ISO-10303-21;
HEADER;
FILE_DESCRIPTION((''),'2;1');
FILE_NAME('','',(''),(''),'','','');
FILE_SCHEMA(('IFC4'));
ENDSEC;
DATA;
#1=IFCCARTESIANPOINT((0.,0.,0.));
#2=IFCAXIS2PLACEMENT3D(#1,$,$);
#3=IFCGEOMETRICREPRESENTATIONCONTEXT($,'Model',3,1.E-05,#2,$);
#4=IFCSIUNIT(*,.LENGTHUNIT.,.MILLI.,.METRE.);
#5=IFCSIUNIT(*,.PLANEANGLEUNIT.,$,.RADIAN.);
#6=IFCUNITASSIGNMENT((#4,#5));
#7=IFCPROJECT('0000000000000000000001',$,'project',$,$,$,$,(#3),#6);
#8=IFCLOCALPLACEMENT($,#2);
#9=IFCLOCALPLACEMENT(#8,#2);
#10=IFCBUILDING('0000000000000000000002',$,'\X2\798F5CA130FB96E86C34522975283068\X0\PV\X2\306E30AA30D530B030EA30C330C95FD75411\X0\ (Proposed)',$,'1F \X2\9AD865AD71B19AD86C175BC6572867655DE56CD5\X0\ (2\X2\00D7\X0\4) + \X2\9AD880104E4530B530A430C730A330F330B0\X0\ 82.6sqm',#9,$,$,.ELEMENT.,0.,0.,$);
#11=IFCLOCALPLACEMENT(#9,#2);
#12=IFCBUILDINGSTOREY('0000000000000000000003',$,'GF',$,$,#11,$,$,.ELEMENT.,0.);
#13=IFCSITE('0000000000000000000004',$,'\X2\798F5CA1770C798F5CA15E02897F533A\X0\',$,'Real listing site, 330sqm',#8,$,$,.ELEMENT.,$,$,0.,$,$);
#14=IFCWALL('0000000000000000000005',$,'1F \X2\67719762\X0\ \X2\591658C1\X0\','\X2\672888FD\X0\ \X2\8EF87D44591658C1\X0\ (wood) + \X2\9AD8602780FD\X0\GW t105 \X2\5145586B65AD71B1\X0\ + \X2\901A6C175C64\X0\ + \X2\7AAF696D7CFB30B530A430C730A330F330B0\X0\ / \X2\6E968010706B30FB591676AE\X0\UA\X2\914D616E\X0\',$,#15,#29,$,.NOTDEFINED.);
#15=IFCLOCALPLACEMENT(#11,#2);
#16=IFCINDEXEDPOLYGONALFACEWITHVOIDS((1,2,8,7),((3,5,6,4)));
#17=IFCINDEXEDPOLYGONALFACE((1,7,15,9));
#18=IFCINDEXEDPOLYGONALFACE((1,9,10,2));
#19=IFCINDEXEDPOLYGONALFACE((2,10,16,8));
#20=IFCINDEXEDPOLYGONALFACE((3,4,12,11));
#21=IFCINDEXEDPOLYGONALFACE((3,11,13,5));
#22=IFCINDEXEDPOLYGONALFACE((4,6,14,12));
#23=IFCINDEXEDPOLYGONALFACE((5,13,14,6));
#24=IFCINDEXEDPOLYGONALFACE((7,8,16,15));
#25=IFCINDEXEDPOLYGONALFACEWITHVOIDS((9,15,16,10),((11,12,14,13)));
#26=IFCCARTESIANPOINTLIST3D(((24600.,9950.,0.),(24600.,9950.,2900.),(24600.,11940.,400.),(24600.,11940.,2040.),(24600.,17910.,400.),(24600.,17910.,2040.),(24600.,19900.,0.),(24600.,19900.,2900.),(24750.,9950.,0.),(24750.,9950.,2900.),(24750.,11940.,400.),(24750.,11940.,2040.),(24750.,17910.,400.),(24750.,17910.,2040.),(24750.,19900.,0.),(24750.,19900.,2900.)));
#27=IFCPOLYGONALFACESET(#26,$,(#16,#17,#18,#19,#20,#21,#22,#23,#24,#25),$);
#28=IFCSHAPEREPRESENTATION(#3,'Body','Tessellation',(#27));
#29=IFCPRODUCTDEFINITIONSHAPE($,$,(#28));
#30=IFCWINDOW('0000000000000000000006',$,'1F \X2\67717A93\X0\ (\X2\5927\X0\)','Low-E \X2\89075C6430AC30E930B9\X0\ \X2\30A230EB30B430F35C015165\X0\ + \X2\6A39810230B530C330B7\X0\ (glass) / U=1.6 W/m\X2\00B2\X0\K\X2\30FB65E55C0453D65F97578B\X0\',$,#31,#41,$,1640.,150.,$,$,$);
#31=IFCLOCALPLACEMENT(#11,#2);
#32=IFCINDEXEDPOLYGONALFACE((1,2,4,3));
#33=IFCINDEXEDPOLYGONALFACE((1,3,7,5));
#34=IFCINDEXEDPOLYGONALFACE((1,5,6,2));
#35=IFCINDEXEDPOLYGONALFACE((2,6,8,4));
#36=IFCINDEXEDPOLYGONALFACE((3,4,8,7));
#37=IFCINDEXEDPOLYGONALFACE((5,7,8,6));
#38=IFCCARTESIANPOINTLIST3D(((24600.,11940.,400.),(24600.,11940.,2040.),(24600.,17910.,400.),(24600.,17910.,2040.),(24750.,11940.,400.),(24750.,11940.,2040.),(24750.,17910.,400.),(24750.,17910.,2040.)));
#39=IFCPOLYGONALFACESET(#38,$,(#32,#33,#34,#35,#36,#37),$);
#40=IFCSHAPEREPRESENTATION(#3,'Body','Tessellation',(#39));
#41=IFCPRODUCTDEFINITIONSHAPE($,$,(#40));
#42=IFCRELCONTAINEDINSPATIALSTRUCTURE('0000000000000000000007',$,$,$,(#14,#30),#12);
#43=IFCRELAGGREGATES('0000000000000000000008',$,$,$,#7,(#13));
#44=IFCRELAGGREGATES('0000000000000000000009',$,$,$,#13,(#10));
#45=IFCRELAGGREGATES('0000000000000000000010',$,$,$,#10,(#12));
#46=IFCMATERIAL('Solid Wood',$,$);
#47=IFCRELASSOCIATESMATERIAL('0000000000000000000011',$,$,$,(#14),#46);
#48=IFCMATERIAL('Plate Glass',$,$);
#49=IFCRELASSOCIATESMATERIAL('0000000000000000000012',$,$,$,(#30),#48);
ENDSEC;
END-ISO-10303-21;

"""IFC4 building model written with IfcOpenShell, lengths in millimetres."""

from ifc_helpers import new_model, si_unit, frame, frame_2d, origin, place, context, project, spatial, rectangle, extrude, material, element, fill, save


model = new_model("IFC4")

# Units and contexts
model_context = context("Model", 3, precision=1e-05, world=origin())
ifc_project = project(units=[si_unit("LENGTHUNIT", "METRE", prefix="MILLI"), si_unit("PLANEANGLEUNIT", "RADIAN")], contexts=[model_context])

# Site, building, storey
site_placement = place(None, origin())
site = spatial("IfcSite", under=ifc_project, at=site_placement, Name="福岡県福岡市西区", ObjectType="Real listing site, 330sqm", CompositionType="ELEMENT", RefElevation=0.0)
building_placement = place(site_placement, origin())
building = spatial("IfcBuilding", under=site, at=building_placement, Name="福岡・雨水利用とPVのオフグリッド志向 (Proposed)", ObjectType="1F 高断熱高気密在来工法 (2×4) + 高耐久サイディング 82.6sqm", CompositionType="ELEMENT", ElevationOfRefHeight=0.0, ElevationOfTerrain=0.0)
storey_placement = place(building_placement, origin())
storey = spatial("IfcBuildingStorey", under=building, at=storey_placement, Name="GF", CompositionType="ELEMENT", Elevation=0.0)

# Shared definitions
ifc_material_1 = material(Name="Solid Wood")

# Wall, opening, window
wall_1_placement = place(storey_placement, frame((12300.0, 4975.0, 0.0)))
wall_1 = element("IfcWall", 1, at=wall_1_placement, inside=storey, material=ifc_material_1, Name="1F 東面 外壁", Description="木製 軸組外壁 (wood) + 高性能GW t105 充填断熱 + 通気層 + 窯業系サイディング / 準耐火・外皮UA配慮", PredefinedType="NOTDEFINED", context=model_context, shape_type="SweptSolid", body=[
    extrude(rectangle(XDim=150.0, YDim=9950.0, at=frame_2d((75.0, 4975.0))), frame((12300.0, 4975.0, 0.0)), (0.0, 0.0, 1.0), 2900.0),
])
opening_placement = place(storey_placement, frame((12300.0, 5970.0, 200.0)))
opening = element("IfcOpeningElement", 2, at=opening_placement, cuts=wall_1, PredefinedType="NOTDEFINED", context=model_context, shape_type="SweptSolid", body=[
    extrude(rectangle(XDim=150.0, YDim=5970.0, at=frame_2d((75.0, 2985.0))), frame((12300.0, 5970.0, 200.0)), (0.0, 0.0, 1.0), 1640.0),
])
ifc_material_2 = material(Name="Plate Glass")
window_placement = place(storey_placement, frame((12300.0, 5970.0, 200.0)))
window = element("IfcWindow", 3, at=window_placement, inside=storey, material=ifc_material_2, Name="1F 東窓 (大)", Description="Low-E 複層ガラス アルゴン封入 + 樹脂サッシ (glass) / U=1.6 W/m²K・日射取得型", OverallHeight=1640.0, OverallWidth=150.0, context=model_context, shape_type="SweptSolid", body=[
    extrude(rectangle(XDim=150.0, YDim=5970.0, at=frame_2d((75.0, 2985.0))), frame((12300.0, 5970.0, 200.0)), (0.0, 0.0, 1.0), 1640.0),
])
fill(opening, window)

save(model, "model.ifc")
